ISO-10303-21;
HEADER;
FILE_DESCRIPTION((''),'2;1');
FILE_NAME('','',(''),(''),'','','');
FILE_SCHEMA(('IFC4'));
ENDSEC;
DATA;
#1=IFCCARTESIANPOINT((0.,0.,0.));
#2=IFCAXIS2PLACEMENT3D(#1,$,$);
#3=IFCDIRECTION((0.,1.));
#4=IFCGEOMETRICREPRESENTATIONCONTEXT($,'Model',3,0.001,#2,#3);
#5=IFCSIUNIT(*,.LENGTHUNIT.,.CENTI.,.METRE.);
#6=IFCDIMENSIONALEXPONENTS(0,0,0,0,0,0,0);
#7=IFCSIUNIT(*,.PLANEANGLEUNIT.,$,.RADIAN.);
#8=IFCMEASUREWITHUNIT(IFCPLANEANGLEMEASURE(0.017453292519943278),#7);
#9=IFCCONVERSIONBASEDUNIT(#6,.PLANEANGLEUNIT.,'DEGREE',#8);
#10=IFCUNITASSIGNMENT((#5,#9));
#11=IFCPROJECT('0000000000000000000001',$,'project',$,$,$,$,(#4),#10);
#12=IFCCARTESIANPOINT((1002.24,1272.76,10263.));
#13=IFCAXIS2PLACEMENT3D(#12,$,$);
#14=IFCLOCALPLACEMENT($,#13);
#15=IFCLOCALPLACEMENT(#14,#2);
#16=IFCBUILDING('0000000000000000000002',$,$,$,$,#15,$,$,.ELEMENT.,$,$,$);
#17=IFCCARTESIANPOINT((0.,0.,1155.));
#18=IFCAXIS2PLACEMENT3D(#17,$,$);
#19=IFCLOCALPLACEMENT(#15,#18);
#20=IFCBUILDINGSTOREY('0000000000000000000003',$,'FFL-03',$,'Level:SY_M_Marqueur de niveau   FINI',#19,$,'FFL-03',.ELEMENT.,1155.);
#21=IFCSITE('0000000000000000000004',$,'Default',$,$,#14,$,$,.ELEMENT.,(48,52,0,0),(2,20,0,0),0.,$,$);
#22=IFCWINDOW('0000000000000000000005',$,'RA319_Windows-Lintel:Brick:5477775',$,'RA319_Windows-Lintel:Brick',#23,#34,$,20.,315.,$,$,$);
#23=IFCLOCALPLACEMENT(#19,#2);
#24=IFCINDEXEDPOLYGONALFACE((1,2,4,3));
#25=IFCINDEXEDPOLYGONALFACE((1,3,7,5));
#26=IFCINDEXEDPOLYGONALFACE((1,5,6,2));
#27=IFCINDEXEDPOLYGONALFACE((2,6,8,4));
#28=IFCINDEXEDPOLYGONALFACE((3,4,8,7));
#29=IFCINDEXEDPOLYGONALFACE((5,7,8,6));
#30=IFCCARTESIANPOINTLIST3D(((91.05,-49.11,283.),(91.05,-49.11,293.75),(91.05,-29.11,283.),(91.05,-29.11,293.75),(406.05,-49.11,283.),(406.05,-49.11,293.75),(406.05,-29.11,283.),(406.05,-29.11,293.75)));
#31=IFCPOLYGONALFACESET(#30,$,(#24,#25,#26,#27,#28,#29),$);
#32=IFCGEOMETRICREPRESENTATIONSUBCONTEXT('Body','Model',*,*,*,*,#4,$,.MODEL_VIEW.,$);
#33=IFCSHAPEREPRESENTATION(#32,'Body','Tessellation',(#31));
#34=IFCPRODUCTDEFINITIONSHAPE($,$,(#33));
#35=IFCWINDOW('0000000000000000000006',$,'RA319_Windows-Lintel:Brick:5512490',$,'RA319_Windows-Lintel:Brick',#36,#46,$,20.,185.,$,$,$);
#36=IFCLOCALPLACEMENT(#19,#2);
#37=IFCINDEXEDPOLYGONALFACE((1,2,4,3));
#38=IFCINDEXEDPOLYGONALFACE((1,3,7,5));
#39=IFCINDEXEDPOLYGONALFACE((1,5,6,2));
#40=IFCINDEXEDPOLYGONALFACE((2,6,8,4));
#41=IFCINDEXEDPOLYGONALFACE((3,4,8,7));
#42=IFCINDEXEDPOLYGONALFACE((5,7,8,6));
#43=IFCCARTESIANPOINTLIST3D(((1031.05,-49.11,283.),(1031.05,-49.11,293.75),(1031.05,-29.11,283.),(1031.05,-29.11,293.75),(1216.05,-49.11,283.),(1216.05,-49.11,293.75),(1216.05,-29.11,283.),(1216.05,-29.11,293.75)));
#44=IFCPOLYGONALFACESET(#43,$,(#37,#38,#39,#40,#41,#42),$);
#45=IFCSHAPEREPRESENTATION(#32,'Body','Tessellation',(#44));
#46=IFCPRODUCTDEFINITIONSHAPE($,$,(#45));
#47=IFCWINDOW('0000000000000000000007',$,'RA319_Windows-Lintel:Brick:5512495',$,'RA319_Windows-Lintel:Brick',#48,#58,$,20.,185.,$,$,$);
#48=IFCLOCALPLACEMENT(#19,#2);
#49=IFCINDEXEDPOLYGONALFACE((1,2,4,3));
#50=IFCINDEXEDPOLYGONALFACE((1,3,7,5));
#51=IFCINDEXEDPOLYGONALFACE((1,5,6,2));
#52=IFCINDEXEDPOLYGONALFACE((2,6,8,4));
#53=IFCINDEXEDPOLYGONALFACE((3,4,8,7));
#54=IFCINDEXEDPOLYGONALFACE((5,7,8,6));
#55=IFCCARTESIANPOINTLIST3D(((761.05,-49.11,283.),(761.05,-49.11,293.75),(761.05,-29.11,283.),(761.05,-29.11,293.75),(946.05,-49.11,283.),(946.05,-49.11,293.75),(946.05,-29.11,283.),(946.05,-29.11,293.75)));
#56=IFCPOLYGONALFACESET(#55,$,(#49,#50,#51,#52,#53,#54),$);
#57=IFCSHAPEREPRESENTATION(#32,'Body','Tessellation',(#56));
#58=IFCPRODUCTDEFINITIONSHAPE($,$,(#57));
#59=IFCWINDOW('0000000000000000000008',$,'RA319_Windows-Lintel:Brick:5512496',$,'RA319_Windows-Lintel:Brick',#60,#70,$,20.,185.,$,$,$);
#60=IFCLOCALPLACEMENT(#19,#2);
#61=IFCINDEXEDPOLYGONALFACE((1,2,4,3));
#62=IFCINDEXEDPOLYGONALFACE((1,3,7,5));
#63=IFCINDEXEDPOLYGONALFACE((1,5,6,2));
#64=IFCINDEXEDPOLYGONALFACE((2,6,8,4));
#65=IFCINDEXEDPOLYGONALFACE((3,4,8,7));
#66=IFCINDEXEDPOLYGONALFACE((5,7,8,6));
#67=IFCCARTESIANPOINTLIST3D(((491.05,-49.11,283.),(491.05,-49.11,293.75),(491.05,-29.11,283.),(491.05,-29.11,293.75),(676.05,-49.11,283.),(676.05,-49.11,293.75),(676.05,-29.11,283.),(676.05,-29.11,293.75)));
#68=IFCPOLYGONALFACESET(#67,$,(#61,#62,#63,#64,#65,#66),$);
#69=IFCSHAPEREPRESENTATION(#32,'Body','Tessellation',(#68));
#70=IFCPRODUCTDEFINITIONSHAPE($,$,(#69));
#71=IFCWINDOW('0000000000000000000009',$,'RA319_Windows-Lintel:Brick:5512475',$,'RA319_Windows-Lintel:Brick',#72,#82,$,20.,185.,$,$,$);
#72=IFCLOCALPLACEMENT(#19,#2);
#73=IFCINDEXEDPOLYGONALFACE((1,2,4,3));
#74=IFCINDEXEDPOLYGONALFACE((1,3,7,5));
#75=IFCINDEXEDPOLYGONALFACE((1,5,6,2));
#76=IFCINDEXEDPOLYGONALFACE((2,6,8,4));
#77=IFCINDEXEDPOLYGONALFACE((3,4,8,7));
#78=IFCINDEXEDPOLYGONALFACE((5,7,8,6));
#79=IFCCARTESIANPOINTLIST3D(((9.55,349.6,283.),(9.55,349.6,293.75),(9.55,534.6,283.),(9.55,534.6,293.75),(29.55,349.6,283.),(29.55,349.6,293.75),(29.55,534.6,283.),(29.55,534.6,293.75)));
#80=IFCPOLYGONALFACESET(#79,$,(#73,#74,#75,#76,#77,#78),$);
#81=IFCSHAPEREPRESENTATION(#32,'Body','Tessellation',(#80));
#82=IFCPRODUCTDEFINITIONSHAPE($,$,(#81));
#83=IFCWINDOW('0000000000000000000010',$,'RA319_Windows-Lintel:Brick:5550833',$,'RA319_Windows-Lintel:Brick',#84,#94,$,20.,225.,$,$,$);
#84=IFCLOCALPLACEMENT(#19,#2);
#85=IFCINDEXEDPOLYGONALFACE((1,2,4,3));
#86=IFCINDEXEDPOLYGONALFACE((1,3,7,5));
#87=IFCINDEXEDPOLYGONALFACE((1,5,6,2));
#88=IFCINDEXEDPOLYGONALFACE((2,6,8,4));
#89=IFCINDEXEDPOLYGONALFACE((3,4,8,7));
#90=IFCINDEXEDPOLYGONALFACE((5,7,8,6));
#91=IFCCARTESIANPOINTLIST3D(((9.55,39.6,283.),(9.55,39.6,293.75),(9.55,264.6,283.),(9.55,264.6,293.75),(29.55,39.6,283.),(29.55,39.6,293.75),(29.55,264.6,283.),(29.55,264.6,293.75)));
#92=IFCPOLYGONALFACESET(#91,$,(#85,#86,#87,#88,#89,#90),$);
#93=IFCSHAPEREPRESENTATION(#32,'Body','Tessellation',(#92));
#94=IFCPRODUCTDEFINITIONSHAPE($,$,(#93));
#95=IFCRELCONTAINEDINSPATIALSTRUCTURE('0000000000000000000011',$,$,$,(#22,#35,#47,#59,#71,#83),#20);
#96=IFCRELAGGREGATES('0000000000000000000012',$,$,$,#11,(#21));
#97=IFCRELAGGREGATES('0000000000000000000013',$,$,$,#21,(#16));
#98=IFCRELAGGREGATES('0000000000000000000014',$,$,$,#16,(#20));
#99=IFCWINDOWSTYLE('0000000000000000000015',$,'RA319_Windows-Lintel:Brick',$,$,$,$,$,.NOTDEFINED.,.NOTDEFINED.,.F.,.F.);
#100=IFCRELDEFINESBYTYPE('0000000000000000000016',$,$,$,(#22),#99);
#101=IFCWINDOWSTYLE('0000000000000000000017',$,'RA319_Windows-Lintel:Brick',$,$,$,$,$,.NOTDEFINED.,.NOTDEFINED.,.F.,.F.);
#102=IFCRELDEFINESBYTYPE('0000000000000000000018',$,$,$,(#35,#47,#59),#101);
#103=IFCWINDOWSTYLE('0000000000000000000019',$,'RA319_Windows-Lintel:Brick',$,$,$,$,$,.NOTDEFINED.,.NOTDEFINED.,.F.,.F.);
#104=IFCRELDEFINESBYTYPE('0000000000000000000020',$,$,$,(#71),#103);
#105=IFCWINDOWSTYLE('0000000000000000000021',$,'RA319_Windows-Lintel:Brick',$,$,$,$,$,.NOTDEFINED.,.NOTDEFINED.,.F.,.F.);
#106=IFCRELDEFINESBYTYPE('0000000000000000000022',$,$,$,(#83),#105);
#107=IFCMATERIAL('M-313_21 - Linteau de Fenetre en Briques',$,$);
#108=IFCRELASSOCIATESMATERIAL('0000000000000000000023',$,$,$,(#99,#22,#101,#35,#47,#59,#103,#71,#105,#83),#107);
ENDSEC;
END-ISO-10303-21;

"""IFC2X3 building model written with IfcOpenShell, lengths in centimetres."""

from ifc_helpers import new_model, entity, si_unit, converted_unit, direction, frame, origin, origin_2d_with_axis, place, context, subcontext, project, spatial, rectangle, extrude, source, transform, mapped, material, type_object, type_shapes, element, save


model = new_model("IFC2X3")

# Units and contexts
model_context = context("Model", 3, precision=0.001, world=origin(), true_north=direction((0.0, 1.0)))
body_context = subcontext(model_context, "Body", "Model", "MODEL_VIEW")
ifc_project = project(units=[si_unit("LENGTHUNIT", "METRE", prefix="CENTI"), converted_unit("PLANEANGLEUNIT", "DEGREE", entity("IfcPlaneAngleMeasure", 0.017453292519943278), si_unit("PLANEANGLEUNIT", "RADIAN"), dimensions=[0, 0, 0, 0, 0, 0, 0])], contexts=[model_context])

# Site, building, storey
site_placement = place(None, frame((1002.24, 1272.76, 10263.0)))
site = spatial("IfcSite", under=ifc_project, at=site_placement, Name="Default", CompositionType="ELEMENT", RefLatitude=(48, 52, 0, 0), RefLongitude=(2, 20, 0, 0), RefElevation=0.0)
building_placement = place(site_placement, origin())
building = spatial("IfcBuilding", under=site, at=building_placement, CompositionType="ELEMENT")
storey_placement = place(building_placement, frame((0.0, 0.0, 1155.0)))
storey = spatial("IfcBuildingStorey", under=building, at=storey_placement, Name="FFL-03", ObjectType="Level:SY_M_Marqueur de niveau   FINI", LongName="FFL-03", CompositionType="ELEMENT", Elevation=1155.0)

# Windows
ifc_material_1 = material(Name="M-313_21 - Linteau de Fenetre en Briques")
window_style_1 = type_object("IfcWindowStyle", Name="RA319_Windows-Lintel:Brick", ConstructionType="NOTDEFINED", OperationType="NOTDEFINED", ParameterTakesPrecedence=False, Sizeable=False, material=ifc_material_1)
shared_shape_1 = source(origin(), body_context, "Body", "SweptSolid", [
    extrude(rectangle(XDim=315.0, YDim=20.0, at=origin_2d_with_axis()), frame((0.0, -10.0, 299.0)), (0.0, 0.0, 1.0), 10.75),
])
type_shapes(window_style_1, [shared_shape_1])
window_1_placement = place(storey_placement, frame((248.55, -49.11, -16.0), z_axis=(0.0, 0.0, 1.0), x_axis=(-1.0, 0.0, 0.0)))
element("IfcWindow", 1, at=window_1_placement, inside=storey, type_object=window_style_1, material=ifc_material_1, Name="RA319_Windows-Lintel:Brick:5477775", ObjectType="RA319_Windows-Lintel:Brick", OverallHeight=20.0, OverallWidth=315.0, context=body_context, shape_type="MappedRepresentation", body=[
    mapped(shared_shape_1, transform((0.0, 0.0, 0.0), scale=1.0)),
])
window_style_2 = type_object("IfcWindowStyle", Name="RA319_Windows-Lintel:Brick", ConstructionType="NOTDEFINED", OperationType="NOTDEFINED", ParameterTakesPrecedence=False, Sizeable=False, material=ifc_material_1)
shared_shape_2 = source(origin(), body_context, "Body", "SweptSolid", [
    extrude(rectangle(XDim=185.0, YDim=20.0, at=origin_2d_with_axis()), frame((0.0, -10.0, 299.0)), (0.0, 0.0, 1.0), 10.75),
])
type_shapes(window_style_2, [shared_shape_2])
for number, where, z_axis, x_axis, name in (
    (2, (1123.55, -49.11, -16.0), (0.0, 0.0, 1.0), (-1.0, 0.0, 0.0), "RA319_Windows-Lintel:Brick:5512490"),
    (3, (853.55, -49.11, -16.0), (0.0, 0.0, 1.0), (-1.0, 0.0, 0.0), "RA319_Windows-Lintel:Brick:5512495"),
    (4, (583.55, -49.11, -16.0), (0.0, 0.0, 1.0), (-1.0, 0.0, 0.0), "RA319_Windows-Lintel:Brick:5512496"),
):
    element("IfcWindow", number, at=place(storey_placement, frame(where, z_axis=z_axis, x_axis=x_axis)), inside=storey, type_object=window_style_2, material=ifc_material_1, Name=name, ObjectType="RA319_Windows-Lintel:Brick", OverallHeight=20.0, OverallWidth=185.0, context=body_context, shape_type="MappedRepresentation", body=[
        mapped(shared_shape_2, transform((0.0, 0.0, 0.0), scale=1.0)),
    ])
window_style_3 = type_object("IfcWindowStyle", Name="RA319_Windows-Lintel:Brick", ConstructionType="NOTDEFINED", OperationType="NOTDEFINED", ParameterTakesPrecedence=False, Sizeable=False, material=ifc_material_1)
shared_shape_3 = source(origin(), body_context, "Body", "SweptSolid", [
    extrude(rectangle(XDim=20.0, YDim=185.0, at=origin_2d_with_axis()), frame((0.0, 10.0, 299.0), z_axis=(0.0, 0.0, 1.0), x_axis=(0.0, -1.0, 0.0)), (0.0, 0.0, 1.0), 10.75),
])
type_shapes(window_style_3, [shared_shape_3])
window_2_placement = place(storey_placement, frame((9.55, 442.1, -16.0), z_axis=(0.0, 0.0, 1.0), x_axis=(0.0, -1.0, 0.0)))
element("IfcWindow", 5, at=window_2_placement, inside=storey, type_object=window_style_3, material=ifc_material_1, Name="RA319_Windows-Lintel:Brick:5512475", ObjectType="RA319_Windows-Lintel:Brick", OverallHeight=20.0, OverallWidth=185.0, context=body_context, shape_type="MappedRepresentation", body=[
    mapped(shared_shape_3, transform((0.0, 0.0, 0.0), scale=1.0)),
])
window_style_4 = type_object("IfcWindowStyle", Name="RA319_Windows-Lintel:Brick", ConstructionType="NOTDEFINED", OperationType="NOTDEFINED", ParameterTakesPrecedence=False, Sizeable=False, material=ifc_material_1)
shared_shape_4 = source(origin(), body_context, "Body", "SweptSolid", [
    extrude(rectangle(XDim=225.0, YDim=20.0, at=origin_2d_with_axis()), frame((0.0, -10.0, 299.0)), (0.0, 0.0, 1.0), 10.75),
])
type_shapes(window_style_4, [shared_shape_4])
window_3_placement = place(storey_placement, frame((9.55, 152.1, -16.0), z_axis=(0.0, 0.0, 1.0), x_axis=(0.0, 1.0, 0.0)))
element("IfcWindow", 6, at=window_3_placement, inside=storey, type_object=window_style_4, material=ifc_material_1, Name="RA319_Windows-Lintel:Brick:5550833", ObjectType="RA319_Windows-Lintel:Brick", OverallHeight=20.0, OverallWidth=225.0, context=body_context, shape_type="MappedRepresentation", body=[
    mapped(shared_shape_4, transform((0.0, 0.0, 0.0), scale=1.0)),
])

save(model, "model.ifc")
